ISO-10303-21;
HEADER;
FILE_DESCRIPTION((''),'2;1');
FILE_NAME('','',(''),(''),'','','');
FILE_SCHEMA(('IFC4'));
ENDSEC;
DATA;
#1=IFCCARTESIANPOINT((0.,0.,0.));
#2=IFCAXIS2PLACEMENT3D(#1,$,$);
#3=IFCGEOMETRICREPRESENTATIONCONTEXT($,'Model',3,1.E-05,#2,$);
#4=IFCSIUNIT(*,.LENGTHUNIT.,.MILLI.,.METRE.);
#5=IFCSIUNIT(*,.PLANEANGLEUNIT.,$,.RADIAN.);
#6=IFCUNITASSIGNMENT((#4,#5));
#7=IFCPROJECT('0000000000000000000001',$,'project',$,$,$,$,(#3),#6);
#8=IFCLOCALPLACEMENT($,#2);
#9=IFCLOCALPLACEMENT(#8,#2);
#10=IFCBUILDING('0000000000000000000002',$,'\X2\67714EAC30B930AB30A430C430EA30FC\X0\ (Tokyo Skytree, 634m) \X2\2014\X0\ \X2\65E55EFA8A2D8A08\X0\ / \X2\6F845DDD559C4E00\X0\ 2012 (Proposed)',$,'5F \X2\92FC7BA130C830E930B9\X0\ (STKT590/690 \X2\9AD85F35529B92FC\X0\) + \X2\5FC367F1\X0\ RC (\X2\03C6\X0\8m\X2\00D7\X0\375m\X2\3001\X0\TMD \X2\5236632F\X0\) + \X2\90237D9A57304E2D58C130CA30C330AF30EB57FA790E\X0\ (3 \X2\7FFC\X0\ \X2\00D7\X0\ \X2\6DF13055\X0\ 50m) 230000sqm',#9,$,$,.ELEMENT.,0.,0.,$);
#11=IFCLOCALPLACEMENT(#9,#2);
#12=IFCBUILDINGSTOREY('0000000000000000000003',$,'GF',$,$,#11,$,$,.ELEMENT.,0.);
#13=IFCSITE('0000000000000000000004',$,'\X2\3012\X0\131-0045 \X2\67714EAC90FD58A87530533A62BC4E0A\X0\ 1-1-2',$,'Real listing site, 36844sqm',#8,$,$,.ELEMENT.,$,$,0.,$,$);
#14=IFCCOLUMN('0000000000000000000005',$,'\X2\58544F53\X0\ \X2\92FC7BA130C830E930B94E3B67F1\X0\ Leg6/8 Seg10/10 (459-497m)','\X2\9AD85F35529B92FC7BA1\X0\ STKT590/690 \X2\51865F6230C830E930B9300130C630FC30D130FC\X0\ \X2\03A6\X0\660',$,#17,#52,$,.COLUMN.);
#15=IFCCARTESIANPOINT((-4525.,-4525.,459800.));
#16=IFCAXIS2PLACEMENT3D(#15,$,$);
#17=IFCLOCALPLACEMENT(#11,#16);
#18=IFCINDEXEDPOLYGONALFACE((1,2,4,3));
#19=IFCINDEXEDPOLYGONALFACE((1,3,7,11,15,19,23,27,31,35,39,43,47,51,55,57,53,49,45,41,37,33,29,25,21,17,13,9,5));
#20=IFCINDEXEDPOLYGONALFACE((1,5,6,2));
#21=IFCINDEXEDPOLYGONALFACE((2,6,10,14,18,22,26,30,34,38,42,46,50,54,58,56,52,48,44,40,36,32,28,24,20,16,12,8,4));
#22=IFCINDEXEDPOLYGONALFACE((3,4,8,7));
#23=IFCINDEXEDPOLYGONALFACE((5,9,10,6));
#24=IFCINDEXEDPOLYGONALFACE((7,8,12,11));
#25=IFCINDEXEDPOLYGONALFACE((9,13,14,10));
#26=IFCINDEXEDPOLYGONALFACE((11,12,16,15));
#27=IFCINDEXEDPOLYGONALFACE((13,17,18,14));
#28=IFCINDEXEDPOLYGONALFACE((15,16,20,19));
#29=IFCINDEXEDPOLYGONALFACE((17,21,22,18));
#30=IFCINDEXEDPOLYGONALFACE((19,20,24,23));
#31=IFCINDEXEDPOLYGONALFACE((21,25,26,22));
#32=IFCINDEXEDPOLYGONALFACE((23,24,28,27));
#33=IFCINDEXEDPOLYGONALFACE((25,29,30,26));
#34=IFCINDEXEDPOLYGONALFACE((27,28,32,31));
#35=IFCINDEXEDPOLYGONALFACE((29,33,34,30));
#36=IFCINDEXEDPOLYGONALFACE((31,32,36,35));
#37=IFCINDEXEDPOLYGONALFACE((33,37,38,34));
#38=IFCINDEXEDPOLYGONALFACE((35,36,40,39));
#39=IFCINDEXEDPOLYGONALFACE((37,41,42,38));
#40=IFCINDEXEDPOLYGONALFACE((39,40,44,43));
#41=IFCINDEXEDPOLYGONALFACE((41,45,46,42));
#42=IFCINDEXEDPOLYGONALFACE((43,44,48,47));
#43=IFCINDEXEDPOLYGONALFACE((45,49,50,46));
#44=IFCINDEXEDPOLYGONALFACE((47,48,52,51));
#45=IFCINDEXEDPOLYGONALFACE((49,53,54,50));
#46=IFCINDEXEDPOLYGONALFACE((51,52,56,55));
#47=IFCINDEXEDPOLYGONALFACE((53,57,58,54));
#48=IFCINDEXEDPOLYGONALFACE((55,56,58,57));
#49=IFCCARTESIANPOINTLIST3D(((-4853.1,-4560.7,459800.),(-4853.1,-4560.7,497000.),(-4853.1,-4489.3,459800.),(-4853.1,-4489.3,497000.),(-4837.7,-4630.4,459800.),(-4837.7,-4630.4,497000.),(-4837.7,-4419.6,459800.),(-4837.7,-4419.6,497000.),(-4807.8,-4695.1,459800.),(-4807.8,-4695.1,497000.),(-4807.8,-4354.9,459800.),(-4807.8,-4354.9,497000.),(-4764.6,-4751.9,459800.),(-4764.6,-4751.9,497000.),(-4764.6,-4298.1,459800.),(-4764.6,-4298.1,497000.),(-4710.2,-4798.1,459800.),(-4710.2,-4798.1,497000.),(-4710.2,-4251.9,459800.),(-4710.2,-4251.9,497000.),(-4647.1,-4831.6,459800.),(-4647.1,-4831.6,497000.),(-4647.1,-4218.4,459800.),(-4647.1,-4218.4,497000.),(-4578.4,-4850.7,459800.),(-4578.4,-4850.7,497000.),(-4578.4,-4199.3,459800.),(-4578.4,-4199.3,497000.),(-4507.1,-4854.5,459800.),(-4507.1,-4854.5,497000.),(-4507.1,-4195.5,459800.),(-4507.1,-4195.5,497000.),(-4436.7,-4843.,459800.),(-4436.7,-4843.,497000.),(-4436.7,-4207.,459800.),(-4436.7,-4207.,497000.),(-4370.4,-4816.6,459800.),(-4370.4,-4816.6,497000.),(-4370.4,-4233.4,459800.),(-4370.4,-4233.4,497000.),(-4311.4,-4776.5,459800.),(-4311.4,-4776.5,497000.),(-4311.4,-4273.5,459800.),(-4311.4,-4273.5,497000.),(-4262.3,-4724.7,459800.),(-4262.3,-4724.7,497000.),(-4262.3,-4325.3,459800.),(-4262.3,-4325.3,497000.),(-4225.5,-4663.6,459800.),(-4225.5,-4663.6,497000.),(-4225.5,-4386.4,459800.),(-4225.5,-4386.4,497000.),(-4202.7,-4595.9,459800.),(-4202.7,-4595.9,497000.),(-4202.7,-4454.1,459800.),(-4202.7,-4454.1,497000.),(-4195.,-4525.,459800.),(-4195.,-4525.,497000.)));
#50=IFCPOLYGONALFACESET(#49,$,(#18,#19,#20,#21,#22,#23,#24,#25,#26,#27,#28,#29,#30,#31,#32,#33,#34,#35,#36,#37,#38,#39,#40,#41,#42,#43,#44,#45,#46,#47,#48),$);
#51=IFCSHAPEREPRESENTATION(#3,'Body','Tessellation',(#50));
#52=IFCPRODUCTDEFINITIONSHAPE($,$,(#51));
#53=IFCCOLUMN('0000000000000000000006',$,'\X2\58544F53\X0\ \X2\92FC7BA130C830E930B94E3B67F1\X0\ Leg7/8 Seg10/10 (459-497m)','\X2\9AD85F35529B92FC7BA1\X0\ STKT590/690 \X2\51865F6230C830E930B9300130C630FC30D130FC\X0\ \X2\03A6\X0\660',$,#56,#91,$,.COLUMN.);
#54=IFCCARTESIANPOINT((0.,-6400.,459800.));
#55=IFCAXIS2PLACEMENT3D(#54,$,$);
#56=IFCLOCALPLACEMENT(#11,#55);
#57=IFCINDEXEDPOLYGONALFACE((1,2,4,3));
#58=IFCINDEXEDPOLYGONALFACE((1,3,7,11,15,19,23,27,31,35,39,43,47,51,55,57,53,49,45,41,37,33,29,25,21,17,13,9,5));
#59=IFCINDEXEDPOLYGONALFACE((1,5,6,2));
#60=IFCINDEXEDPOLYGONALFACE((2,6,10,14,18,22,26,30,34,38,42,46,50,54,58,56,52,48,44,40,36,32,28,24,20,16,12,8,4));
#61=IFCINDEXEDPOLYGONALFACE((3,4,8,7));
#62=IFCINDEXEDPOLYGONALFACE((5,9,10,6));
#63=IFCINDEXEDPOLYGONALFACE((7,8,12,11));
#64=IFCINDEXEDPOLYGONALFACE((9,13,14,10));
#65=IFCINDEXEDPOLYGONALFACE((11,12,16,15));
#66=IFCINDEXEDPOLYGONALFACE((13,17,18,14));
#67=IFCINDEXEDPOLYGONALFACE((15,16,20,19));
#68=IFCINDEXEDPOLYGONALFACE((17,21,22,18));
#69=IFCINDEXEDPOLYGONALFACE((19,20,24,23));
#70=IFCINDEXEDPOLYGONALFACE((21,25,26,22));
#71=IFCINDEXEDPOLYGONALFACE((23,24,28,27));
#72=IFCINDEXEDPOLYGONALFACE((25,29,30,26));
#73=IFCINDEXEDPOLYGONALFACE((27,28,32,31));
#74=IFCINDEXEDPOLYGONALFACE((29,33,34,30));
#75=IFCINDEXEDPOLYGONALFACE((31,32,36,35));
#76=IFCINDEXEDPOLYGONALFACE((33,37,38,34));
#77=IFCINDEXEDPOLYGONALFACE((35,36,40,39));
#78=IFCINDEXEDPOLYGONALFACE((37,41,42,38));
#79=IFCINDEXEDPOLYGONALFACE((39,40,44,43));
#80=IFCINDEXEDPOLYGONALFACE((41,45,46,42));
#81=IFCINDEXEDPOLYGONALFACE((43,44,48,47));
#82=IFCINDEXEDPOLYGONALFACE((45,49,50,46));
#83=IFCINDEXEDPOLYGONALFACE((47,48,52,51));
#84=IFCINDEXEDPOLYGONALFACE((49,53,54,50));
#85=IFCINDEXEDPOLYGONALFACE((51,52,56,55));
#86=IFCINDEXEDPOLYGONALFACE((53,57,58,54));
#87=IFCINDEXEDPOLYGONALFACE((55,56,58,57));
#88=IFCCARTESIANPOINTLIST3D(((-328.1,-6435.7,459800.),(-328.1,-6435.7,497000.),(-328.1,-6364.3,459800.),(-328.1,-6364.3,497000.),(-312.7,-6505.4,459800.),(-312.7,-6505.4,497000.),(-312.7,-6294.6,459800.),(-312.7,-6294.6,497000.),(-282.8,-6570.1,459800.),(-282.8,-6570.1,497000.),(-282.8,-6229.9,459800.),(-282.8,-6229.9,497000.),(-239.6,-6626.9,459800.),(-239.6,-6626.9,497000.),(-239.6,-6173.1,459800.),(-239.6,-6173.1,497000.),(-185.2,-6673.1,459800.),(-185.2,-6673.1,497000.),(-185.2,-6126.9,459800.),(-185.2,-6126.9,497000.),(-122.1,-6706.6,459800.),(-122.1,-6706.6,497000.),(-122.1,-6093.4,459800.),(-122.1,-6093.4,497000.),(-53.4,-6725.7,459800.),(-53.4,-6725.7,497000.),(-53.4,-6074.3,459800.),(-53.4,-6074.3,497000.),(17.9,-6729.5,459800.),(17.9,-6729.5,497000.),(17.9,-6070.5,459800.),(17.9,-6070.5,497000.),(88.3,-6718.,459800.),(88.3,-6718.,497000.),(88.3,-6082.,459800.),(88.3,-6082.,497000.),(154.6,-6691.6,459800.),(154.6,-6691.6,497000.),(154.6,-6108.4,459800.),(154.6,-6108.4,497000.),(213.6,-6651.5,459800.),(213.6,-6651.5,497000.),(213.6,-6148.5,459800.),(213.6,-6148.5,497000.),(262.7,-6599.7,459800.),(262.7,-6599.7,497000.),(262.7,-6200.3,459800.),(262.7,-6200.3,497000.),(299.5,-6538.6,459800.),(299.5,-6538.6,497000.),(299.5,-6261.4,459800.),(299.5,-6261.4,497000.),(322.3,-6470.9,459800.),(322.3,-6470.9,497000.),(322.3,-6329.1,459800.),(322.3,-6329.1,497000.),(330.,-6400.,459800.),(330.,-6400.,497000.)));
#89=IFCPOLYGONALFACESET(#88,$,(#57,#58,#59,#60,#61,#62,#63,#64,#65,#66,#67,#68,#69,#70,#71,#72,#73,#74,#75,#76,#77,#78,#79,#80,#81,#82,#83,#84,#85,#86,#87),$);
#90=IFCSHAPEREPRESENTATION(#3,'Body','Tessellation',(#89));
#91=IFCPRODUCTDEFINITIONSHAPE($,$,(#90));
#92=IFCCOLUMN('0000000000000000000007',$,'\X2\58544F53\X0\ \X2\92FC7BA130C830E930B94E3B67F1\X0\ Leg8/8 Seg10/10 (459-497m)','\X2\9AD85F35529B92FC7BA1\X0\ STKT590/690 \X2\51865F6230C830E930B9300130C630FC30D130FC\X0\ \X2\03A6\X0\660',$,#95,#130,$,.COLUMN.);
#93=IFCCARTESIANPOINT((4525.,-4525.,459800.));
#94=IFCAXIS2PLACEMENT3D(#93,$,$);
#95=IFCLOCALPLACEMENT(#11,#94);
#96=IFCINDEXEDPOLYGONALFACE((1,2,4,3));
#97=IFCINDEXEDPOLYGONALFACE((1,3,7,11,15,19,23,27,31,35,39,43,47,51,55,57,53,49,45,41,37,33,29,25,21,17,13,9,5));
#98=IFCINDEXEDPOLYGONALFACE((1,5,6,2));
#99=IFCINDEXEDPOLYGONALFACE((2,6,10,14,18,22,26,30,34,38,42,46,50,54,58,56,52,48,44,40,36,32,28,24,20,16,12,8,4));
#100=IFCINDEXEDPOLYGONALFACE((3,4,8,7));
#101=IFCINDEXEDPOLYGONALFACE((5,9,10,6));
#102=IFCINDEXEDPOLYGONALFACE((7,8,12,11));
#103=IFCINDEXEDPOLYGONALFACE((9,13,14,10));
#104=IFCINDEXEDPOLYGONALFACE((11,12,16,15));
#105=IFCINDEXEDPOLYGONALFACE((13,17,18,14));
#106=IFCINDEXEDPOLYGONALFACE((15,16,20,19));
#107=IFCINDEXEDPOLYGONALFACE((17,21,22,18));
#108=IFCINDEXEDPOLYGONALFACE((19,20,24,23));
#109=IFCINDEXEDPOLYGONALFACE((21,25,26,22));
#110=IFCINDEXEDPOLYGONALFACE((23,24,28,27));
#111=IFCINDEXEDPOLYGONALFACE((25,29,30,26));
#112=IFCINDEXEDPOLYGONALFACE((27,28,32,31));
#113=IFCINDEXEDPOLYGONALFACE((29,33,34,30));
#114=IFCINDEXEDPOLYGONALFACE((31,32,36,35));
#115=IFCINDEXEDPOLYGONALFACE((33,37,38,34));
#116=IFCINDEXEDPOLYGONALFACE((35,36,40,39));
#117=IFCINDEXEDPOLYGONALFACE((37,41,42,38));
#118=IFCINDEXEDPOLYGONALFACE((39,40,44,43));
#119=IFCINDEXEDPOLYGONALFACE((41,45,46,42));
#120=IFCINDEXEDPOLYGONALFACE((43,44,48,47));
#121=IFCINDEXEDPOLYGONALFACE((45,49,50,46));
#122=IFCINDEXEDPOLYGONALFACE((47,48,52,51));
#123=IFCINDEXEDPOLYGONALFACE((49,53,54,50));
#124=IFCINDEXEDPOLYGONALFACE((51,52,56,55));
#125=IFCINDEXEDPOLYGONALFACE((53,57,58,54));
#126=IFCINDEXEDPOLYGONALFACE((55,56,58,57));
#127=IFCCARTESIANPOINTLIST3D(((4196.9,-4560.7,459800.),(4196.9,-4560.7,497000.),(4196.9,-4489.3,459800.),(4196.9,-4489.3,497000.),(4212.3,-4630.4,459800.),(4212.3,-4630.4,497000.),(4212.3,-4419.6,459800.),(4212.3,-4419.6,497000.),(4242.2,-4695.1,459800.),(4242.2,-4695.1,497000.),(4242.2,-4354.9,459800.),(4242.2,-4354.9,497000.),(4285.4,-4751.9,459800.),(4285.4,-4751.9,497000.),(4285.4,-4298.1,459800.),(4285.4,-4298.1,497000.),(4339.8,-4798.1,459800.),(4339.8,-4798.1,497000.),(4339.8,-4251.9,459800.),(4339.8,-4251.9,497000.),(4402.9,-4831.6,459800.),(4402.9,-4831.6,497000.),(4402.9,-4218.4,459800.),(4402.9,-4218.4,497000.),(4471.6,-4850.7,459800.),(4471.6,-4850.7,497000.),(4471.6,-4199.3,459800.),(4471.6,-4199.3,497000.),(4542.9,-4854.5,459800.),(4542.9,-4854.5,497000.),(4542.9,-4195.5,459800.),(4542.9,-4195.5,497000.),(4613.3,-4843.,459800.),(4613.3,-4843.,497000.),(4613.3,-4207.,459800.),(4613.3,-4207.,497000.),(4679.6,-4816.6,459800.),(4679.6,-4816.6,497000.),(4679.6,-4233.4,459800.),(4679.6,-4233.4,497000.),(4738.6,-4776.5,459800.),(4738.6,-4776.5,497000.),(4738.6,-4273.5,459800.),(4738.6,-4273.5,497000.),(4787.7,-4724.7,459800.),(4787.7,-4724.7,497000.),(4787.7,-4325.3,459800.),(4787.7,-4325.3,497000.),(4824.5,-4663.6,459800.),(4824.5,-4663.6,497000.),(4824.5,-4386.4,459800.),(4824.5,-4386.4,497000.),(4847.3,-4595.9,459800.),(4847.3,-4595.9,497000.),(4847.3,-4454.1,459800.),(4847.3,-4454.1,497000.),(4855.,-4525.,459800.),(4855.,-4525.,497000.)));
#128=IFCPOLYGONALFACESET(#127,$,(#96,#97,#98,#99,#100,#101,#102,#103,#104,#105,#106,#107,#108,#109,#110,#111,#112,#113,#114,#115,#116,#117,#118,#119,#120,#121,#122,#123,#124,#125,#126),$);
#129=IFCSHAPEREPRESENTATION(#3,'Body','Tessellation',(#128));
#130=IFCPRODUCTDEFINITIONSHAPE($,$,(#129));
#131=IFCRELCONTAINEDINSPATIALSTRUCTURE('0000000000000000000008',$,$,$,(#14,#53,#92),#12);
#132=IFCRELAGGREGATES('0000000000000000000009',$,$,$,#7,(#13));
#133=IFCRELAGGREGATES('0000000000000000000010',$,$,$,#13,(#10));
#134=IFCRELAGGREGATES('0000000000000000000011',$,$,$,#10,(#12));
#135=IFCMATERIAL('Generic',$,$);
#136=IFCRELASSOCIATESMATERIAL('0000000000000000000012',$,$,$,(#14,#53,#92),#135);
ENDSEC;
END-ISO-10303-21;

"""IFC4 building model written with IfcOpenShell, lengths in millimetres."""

from ifc_helpers import new_model, si_unit, frame, origin, origin_2d, place, context, project, spatial, circle, extrude, material, element, save


model = new_model("IFC4")

# Units and contexts
model_context = context("Model", 3, precision=1e-05, world=origin())
ifc_project = project(units=[si_unit("LENGTHUNIT", "METRE", prefix="MILLI"), si_unit("PLANEANGLEUNIT", "RADIAN")], contexts=[model_context])

# Site, building, storey
site_placement = place(None, origin())
site = spatial("IfcSite", under=ifc_project, at=site_placement, Name="〒131-0045 東京都墨田区押上 1-1-2", ObjectType="Real listing site, 36844sqm", CompositionType="ELEMENT", RefElevation=0.0)
building_placement = place(site_placement, origin())
building = spatial("IfcBuilding", under=site, at=building_placement, Name="東京スカイツリー (Tokyo Skytree, 634m) — 日建設計 / 澄川喜一 2012 (Proposed)", ObjectType="5F 鋼管トラス (STKT590/690 高張力鋼) + 心柱 RC (φ8m×375m、TMD 制振) + 連続地中壁ナックル基礎 (3 翼 × 深さ 50m) 230000sqm", CompositionType="ELEMENT", ElevationOfRefHeight=0.0, ElevationOfTerrain=0.0)
storey_placement = place(building_placement, origin())
storey = spatial("IfcBuildingStorey", under=building, at=storey_placement, Name="GF", CompositionType="ELEMENT", Elevation=0.0)

# Columns
ifc_material = material(Name="Generic")
column_1_placement = place(storey_placement, frame((-4525.0, -4525.0, 459800.0)))
element("IfcColumn", 1, at=column_1_placement, inside=storey, material=ifc_material, Name="塔体 鋼管トラス主柱 Leg6/8 Seg10/10 (459-497m)", Description="高張力鋼管 STKT590/690 円形トラス、テーパー Φ660", PredefinedType="COLUMN", context=model_context, shape_type="SweptSolid", body=[
    extrude(circle(Radius=330.0, at=origin_2d()), frame((-4525.0, -4525.0, 459800.0)), (0.0, 0.0, 1.0), 37200.0),
])
column_2_placement = place(storey_placement, frame((0.0, -6400.0, 459800.0)))
element("IfcColumn", 2, at=column_2_placement, inside=storey, material=ifc_material, Name="塔体 鋼管トラス主柱 Leg7/8 Seg10/10 (459-497m)", Description="高張力鋼管 STKT590/690 円形トラス、テーパー Φ660", PredefinedType="COLUMN", context=model_context, shape_type="SweptSolid", body=[
    extrude(circle(Radius=330.0, at=origin_2d()), frame((0.0, -6400.0, 459800.0)), (0.0, 0.0, 1.0), 37200.0),
])
column_3_placement = place(storey_placement, frame((4525.0, -4525.0, 459800.0)))
element("IfcColumn", 3, at=column_3_placement, inside=storey, material=ifc_material, Name="塔体 鋼管トラス主柱 Leg8/8 Seg10/10 (459-497m)", Description="高張力鋼管 STKT590/690 円形トラス、テーパー Φ660", PredefinedType="COLUMN", context=model_context, shape_type="SweptSolid", body=[
    extrude(circle(Radius=330.0, at=origin_2d()), frame((4525.0, -4525.0, 459800.0)), (0.0, 0.0, 1.0), 37200.0),
])

save(model, "model.ifc")
